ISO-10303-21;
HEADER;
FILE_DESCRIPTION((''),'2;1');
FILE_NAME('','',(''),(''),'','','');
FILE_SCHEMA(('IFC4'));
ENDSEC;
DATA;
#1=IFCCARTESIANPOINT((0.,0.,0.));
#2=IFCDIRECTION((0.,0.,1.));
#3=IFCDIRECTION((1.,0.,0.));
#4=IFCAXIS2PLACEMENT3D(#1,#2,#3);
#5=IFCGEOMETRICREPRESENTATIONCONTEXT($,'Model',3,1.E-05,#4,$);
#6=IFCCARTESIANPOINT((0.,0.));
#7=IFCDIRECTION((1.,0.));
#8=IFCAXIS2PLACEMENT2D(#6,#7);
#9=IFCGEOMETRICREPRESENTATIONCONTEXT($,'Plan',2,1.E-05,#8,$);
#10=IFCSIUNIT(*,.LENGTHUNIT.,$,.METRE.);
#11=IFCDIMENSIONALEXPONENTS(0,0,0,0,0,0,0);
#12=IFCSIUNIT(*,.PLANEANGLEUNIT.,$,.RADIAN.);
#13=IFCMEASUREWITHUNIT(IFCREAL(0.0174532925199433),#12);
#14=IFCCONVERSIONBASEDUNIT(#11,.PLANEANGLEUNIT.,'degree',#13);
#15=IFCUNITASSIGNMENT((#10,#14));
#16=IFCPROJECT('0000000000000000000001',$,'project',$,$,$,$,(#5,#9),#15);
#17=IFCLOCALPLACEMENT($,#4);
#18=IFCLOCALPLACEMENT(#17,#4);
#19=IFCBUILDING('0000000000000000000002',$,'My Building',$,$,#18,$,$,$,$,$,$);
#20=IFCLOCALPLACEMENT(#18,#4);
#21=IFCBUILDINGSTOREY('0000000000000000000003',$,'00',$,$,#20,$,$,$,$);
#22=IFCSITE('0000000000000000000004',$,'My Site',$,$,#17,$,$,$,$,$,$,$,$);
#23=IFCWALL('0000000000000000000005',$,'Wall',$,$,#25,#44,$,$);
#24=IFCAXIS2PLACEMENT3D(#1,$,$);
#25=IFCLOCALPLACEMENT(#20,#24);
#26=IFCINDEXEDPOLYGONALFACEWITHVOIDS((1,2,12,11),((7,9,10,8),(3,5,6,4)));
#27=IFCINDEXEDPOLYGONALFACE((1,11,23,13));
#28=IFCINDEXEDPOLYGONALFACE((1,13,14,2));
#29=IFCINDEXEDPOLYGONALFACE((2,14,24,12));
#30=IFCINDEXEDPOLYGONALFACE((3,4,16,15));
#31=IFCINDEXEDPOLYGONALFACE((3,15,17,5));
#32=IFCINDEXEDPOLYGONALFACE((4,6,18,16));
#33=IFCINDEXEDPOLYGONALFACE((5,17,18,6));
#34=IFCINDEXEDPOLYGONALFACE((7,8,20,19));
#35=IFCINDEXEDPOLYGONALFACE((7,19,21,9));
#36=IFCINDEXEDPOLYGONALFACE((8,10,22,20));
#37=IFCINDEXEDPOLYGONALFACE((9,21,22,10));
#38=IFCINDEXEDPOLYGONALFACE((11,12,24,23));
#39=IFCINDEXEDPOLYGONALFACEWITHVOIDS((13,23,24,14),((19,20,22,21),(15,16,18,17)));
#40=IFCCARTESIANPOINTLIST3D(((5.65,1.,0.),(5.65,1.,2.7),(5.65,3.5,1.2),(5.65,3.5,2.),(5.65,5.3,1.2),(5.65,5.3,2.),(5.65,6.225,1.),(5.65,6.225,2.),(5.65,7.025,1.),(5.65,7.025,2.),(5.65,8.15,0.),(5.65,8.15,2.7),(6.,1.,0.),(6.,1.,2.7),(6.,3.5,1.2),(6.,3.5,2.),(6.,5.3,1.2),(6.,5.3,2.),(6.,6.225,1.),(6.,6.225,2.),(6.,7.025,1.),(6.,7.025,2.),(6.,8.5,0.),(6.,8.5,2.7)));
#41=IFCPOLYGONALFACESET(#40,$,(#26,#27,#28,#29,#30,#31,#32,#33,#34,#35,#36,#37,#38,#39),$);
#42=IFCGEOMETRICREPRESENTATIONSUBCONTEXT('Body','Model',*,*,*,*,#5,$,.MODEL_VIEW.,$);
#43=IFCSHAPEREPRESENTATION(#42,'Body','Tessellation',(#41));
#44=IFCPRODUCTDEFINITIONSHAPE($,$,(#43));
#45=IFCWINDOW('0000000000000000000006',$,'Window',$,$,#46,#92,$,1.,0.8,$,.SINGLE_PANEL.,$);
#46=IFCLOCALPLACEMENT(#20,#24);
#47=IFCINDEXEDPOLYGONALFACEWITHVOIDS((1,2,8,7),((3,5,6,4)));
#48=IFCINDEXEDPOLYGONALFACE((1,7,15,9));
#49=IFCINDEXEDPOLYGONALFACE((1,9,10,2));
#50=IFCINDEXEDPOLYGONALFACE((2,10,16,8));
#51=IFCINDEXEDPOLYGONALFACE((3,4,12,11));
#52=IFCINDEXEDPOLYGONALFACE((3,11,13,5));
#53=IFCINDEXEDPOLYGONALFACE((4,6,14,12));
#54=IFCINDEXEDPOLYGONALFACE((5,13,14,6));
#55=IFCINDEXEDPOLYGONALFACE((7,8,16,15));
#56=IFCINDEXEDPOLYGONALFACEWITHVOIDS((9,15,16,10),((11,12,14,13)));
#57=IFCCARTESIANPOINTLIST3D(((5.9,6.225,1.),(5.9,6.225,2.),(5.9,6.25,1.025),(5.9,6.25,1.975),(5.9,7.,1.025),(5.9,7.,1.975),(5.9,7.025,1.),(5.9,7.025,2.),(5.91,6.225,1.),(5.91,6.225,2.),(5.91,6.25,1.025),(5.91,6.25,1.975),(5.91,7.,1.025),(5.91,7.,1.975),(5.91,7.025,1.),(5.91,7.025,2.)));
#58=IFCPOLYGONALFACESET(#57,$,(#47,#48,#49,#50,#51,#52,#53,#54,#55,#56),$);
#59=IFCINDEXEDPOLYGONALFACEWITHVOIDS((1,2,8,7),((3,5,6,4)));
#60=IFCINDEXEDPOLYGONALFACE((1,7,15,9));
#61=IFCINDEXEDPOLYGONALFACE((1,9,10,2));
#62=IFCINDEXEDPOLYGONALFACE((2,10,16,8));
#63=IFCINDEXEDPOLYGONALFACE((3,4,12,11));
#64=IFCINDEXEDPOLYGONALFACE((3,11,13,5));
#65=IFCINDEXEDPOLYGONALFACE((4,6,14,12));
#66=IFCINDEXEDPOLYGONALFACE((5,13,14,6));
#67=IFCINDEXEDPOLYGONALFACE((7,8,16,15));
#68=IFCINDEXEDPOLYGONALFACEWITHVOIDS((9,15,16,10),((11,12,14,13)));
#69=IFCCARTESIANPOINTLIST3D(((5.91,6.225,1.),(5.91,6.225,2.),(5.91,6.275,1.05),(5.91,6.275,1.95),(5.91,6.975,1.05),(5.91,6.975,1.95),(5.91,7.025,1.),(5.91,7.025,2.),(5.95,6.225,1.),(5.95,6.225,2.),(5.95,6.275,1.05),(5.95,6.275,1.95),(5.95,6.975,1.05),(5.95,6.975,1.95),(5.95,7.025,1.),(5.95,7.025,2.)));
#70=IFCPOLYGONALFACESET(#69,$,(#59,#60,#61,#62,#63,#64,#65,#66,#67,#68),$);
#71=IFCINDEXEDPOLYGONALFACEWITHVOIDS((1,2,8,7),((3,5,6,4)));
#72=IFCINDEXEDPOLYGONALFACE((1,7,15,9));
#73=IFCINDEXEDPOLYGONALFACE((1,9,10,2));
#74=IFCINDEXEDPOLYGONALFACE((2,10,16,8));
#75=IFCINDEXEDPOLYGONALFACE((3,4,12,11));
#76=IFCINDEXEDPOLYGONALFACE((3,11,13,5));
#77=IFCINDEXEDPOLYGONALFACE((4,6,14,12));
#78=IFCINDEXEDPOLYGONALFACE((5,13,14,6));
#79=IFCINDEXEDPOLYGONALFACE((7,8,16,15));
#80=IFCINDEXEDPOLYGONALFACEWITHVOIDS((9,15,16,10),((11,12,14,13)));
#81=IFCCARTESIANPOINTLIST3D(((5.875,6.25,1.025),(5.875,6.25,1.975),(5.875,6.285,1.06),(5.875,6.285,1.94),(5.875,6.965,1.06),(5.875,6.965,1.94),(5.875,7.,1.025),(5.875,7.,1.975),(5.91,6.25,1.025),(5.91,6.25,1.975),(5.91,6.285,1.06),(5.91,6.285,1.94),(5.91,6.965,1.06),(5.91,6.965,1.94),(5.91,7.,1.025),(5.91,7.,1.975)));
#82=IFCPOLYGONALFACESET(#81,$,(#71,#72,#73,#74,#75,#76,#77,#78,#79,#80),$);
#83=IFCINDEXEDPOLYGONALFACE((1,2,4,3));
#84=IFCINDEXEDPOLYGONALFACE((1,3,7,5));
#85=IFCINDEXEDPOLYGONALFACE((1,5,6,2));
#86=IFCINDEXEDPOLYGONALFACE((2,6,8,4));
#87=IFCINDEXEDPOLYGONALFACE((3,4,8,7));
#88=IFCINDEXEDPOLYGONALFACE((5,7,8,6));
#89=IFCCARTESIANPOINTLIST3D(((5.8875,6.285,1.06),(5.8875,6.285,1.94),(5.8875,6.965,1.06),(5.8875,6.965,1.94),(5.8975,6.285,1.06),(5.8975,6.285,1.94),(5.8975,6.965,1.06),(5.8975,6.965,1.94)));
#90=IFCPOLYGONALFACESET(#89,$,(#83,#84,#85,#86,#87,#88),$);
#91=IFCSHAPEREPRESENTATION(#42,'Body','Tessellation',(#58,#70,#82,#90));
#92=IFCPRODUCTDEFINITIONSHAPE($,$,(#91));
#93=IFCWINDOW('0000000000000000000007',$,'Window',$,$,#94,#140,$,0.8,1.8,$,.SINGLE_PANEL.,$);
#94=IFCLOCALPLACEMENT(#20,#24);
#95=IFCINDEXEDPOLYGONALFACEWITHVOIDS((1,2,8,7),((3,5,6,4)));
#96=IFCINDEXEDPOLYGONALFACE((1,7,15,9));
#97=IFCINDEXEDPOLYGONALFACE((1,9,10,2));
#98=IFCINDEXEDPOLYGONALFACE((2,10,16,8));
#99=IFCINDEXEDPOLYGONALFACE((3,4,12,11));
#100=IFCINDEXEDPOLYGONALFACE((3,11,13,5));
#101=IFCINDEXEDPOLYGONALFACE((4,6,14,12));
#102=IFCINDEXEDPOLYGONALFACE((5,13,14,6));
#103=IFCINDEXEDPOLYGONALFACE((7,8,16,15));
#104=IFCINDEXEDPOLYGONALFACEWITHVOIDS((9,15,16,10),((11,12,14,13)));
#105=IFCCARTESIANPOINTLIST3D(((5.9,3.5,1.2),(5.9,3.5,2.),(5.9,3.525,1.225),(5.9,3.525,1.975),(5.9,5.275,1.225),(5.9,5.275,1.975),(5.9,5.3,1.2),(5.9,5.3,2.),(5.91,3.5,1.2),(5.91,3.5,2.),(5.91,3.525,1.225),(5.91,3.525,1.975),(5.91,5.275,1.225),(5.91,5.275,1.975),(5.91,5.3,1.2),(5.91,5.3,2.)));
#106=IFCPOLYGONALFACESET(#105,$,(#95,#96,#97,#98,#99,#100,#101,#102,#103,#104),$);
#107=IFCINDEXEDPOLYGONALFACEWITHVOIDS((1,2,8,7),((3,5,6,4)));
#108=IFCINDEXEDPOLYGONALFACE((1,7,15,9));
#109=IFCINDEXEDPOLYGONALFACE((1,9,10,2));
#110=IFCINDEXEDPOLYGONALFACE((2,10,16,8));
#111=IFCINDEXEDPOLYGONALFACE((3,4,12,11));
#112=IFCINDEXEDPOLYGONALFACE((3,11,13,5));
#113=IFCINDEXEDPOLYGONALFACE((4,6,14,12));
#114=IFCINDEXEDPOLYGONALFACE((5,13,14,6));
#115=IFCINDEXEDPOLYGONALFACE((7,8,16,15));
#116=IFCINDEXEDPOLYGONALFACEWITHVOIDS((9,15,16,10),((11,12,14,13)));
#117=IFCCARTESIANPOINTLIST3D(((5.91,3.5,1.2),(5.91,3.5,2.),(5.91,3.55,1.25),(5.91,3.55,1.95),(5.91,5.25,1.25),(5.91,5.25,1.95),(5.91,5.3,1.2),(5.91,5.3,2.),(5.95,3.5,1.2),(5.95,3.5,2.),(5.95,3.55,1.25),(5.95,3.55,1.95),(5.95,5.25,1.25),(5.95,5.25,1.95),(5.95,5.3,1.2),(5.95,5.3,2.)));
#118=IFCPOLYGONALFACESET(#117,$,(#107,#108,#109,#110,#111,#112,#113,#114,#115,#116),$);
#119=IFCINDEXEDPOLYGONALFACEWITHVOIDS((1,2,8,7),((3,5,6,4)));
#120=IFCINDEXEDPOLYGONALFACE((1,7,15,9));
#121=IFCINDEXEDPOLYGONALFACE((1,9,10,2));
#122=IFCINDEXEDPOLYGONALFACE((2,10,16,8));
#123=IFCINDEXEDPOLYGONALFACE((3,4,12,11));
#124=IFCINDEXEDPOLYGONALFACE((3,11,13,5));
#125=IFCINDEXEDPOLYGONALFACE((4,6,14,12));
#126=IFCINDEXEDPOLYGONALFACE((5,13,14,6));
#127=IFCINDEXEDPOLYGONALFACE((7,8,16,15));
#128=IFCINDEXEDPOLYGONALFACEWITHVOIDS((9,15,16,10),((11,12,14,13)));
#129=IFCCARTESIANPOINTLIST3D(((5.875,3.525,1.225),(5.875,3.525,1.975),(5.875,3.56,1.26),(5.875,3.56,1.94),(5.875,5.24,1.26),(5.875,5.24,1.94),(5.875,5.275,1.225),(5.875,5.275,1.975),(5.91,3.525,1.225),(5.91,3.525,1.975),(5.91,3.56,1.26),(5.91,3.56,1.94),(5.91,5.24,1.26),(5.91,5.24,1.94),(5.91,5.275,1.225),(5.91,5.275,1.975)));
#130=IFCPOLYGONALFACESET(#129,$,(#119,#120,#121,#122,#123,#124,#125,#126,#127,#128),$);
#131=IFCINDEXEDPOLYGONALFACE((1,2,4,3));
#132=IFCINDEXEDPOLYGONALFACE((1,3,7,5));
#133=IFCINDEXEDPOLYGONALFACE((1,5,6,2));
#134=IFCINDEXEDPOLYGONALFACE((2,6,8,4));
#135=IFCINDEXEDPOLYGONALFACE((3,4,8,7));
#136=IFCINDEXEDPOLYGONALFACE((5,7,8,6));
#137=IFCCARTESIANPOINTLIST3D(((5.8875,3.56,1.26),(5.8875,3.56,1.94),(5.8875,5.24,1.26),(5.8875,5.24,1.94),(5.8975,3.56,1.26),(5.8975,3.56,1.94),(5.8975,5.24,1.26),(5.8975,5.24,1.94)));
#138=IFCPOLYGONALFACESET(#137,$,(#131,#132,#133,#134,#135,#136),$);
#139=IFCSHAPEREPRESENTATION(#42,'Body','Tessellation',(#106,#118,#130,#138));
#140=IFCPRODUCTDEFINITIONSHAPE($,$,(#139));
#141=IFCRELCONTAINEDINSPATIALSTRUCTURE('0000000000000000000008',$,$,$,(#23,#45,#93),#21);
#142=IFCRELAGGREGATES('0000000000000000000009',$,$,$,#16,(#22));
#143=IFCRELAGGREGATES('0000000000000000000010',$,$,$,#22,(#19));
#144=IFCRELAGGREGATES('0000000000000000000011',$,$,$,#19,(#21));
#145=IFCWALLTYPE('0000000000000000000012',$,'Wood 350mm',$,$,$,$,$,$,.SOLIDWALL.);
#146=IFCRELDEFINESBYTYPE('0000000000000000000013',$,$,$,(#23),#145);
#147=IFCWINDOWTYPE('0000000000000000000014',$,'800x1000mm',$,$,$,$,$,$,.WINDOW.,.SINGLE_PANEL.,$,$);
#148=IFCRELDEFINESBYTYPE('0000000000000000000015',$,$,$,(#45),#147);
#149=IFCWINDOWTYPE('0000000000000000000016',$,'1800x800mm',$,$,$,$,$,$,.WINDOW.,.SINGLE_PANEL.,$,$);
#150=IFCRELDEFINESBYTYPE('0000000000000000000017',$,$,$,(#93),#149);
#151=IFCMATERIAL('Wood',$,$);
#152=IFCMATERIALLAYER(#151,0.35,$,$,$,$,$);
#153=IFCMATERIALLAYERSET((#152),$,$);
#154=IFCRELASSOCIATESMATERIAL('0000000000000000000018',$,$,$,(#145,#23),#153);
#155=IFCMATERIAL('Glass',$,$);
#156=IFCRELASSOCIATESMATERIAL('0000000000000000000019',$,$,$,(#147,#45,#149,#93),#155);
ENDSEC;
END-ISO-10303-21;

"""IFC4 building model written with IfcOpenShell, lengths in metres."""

from ifc_helpers import new_model, entity, si_unit, converted_unit, frame, origin_with_axes, origin_2d_with_axis, place, context, subcontext, project, spatial, line, indexed_curve, outline, extrude, clip, halfspace, shape, source, transform, mapped, material, layer, layer_set, layer_usage, type_object, type_shapes, element, fill, save


model = new_model("IFC4")

# Units and contexts
model_context = context("Model", 3, precision=1e-05, world=origin_with_axes())
plan_context = context("Plan", 2, precision=1e-05, world=origin_2d_with_axis())
body_context_1 = subcontext(model_context, "Body", "Model", "MODEL_VIEW")
body_context_2 = subcontext(plan_context, "Body", "Plan", "PLAN_VIEW")
ifc_project = project(units=[si_unit("LENGTHUNIT", "METRE"), converted_unit("PLANEANGLEUNIT", "degree", entity("IfcReal", 0.0174532925199433), si_unit("PLANEANGLEUNIT", "RADIAN"), dimensions=[0, 0, 0, 0, 0, 0, 0])], contexts=[model_context, plan_context])

# Site, building, storey
site_placement = place(None, origin_with_axes())
site = spatial("IfcSite", under=ifc_project, at=site_placement, Name="My Site")
building_placement = place(site_placement, origin_with_axes())
building = spatial("IfcBuilding", under=site, at=building_placement, Name="My Building")
storey_placement = place(building_placement, origin_with_axes())
storey = spatial("IfcBuildingStorey", under=building, at=storey_placement, Name="00")

# Shared definitions
ifc_material_1 = material(Name="Wood")

# Wall, openings, windows
ifc_layer_1 = layer(ifc_material_1, 0.35)
ifc_layer_set_1 = layer_set([ifc_layer_1])
ifc_layer_usage_1 = layer_usage(ifc_layer_set_1, "AXIS2", "POSITIVE", 0.0)
wall_type_1 = type_object("IfcWallType", Name="Wood 350mm", PredefinedType="SOLIDWALL", material=ifc_layer_set_1)
wall_1_placement = place(storey_placement, frame((6.0, 1.0, 0.0), z_axis=(0.0, 0.0, 1.0), x_axis=(0.0, 1.0, 0.0)))
wall_1 = element("IfcWall", 1, at=wall_1_placement, inside=storey, type_object=wall_type_1, material=ifc_layer_usage_1, Name="Wall", context=body_context_1, shape_type="Clipping", body=[
    clip(extrude(outline(indexed_curve([(0.0, 0.0), (0.0, 0.35), (7.5, 0.35), (7.5, 0.0), (0.0, 0.0)], self_intersect=False)), origin_with_axes(), (0.0, 0.0, 1.0), 2.7), halfspace(frame((7.5, 0.0, 0.0), z_axis=(0.707107, 0.707107, 0.0), x_axis=(0.707107, -0.707107, 0.0)), False)),
])
shared_shape_1 = source(origin_with_axes(), body_context_1, "Body", "SweptSolid", [
    extrude(outline(indexed_curve([(0.0, 0.0), (0.8, 0.0), (0.8, 1.0), (0.0, 1.0)], segments=[line(1, 2, 3, 4, 1)])), frame((0.0, -0.6, 0.0), z_axis=(0.0, -1.0, 0.0), x_axis=(1.0, 0.0, 0.0)), (0.0, 0.0, -1.0), 1.2),
])
opening_1_placement = place(wall_1_placement, frame((5.225, 0.0, 1.0), z_axis=(0.0, 0.0, 1.0), x_axis=(1.0, 0.0, 0.0)))
opening_1 = element("IfcOpeningElement", 2, at=opening_1_placement, cuts=wall_1, PredefinedType="OPENING", context=body_context_1, shape_type="MappedRepresentation", body=[
    mapped(shared_shape_1, transform((0.0, 0.0, 0.0), x_axis=(1.0, 0.0, 0.0), y_axis=(0.0, 1.0, 0.0), z_axis=(0.0, 0.0, 1.0), scale=1.0)),
])
shared_shape_2 = source(origin_with_axes(), body_context_1, "Body", "SweptSolid", [
    extrude(outline(indexed_curve([(0.0, 0.0), (1.8, 0.0), (1.8, 0.8), (0.0, 0.8)], segments=[line(1, 2, 3, 4, 1)])), frame((0.0, -0.6, 0.0), z_axis=(0.0, -1.0, 0.0), x_axis=(1.0, 0.0, 0.0)), (0.0, 0.0, -1.0), 1.2),
])
opening_2_placement = place(wall_1_placement, frame((2.5, 0.0, 1.2), z_axis=(0.0, 0.0, 1.0), x_axis=(1.0, 0.0, 0.0)))
opening_2 = element("IfcOpeningElement", 3, at=opening_2_placement, cuts=wall_1, PredefinedType="OPENING", context=body_context_1, shape_type="MappedRepresentation", body=[
    mapped(shared_shape_2, transform((0.0, 0.0, 0.0), x_axis=(1.0, 0.0, 0.0), y_axis=(0.0, 1.0, 0.0), z_axis=(0.0, 0.0, 1.0), scale=1.0)),
])
ifc_material_2 = material(Name="Glass")
window_type_1 = type_object("IfcWindowType", Name="800x1000mm", PartitioningType="SINGLE_PANEL", PredefinedType="WINDOW", material=ifc_material_2)
shared_shape_3 = source(origin_with_axes(), body_context_1, "Body", "SweptSolid", [
    extrude(outline(indexed_curve([(0.0, 0.0), (0.8, 0.0), (0.8, 1.0), (0.0, 1.0)], segments=[line(1, 2, 3, 4, 1)]), holes=[indexed_curve([(0.025, 0.025), (0.775, 0.025), (0.775, 0.975), (0.025, 0.975)], segments=[line(1, 2, 3, 4, 1)])]), frame((0.0, 0.09, 0.0), z_axis=(0.0, -1.0, 0.0), x_axis=(1.0, 0.0, 0.0)), (0.0, 0.0, -1.0), 0.01),
    extrude(outline(indexed_curve([(0.0, 0.0), (0.8, 0.0), (0.8, 1.0), (0.0, 1.0)], segments=[line(1, 2, 3, 4, 1)]), holes=[indexed_curve([(0.05, 0.05), (0.75, 0.05), (0.75, 0.95), (0.05, 0.95)], segments=[line(1, 2, 3, 4, 1)])]), frame((0.0, 0.05, 0.0), z_axis=(0.0, -1.0, 0.0), x_axis=(1.0, 0.0, 0.0)), (0.0, 0.0, -1.0), 0.04),
    extrude(outline(indexed_curve([(0.0, 0.0), (0.75, 0.0), (0.75, 0.95), (0.0, 0.95)], segments=[line(1, 2, 3, 4, 1)]), holes=[indexed_curve([(0.035, 0.035), (0.715, 0.035), (0.715, 0.915), (0.035, 0.915)], segments=[line(1, 2, 3, 4, 1)])]), frame((0.025, 0.09, 0.025), z_axis=(0.0, -1.0, 0.0), x_axis=(1.0, 0.0, 0.0)), (0.0, 0.0, -1.0), 0.035),
    extrude(outline(indexed_curve([(0.035, 0.035), (0.715, 0.035), (0.715, 0.915), (0.035, 0.915)], segments=[line(1, 2, 3, 4, 1)])), frame((0.025, 0.1025, 0.025), z_axis=(0.0, -1.0, 0.0), x_axis=(1.0, 0.0, 0.0)), (0.0, 0.0, -1.0), 0.01),
])
shared_shape_4 = source(origin_with_axes(), body_context_2, "Body", "Curve2D", [
    entity("IfcIndexedPolyCurve", entity("IfcCartesianPointList2D", [[0.05, 0.05], [0.75, 0.05]])),
    entity("IfcIndexedPolyCurve", entity("IfcCartesianPointList2D", [[0.0, 0.1], [0.025, 0.1], [0.025, 0.09], [0.05, 0.09], [0.05, 0.05], [0.0, 0.05]]), [entity("IfcLineIndex", [1, 2, 3, 4, 5, 6, 1])]),
    entity("IfcIndexedPolyCurve", entity("IfcCartesianPointList2D", [[0.8, 0.1], [0.775, 0.1], [0.775, 0.09], [0.75, 0.09], [0.75, 0.05], [0.8, 0.05]]), [entity("IfcLineIndex", [1, 2, 3, 4, 5, 6, 1])]),
    entity("IfcIndexedPolyCurve", entity("IfcCartesianPointList2D", [[0.025, 0.09], [0.06, 0.09], [0.06, 0.125], [0.025, 0.125]]), [entity("IfcLineIndex", [1, 2, 3, 4, 1])]),
    entity("IfcIndexedPolyCurve", entity("IfcCartesianPointList2D", [[0.775, 0.09], [0.74, 0.09], [0.74, 0.125], [0.775, 0.125]]), [entity("IfcLineIndex", [1, 2, 3, 4, 1])]),
    entity("IfcIndexedPolyCurve", entity("IfcCartesianPointList2D", [[0.06, 0.09], [0.74, 0.09]])),
    entity("IfcIndexedPolyCurve", entity("IfcCartesianPointList2D", [[0.06, 0.125], [0.74, 0.125]])),
    entity("IfcIndexedPolyCurve", entity("IfcCartesianPointList2D", [[0.06, 0.1075], [0.74, 0.1075]])),
])
type_shapes(window_type_1, [shared_shape_3, shared_shape_4])
window_1_placement = place(opening_1_placement, origin_with_axes())
window_1 = element("IfcWindow", 4, at=window_1_placement, inside=storey, type_object=window_type_1, material=ifc_material_2, Name="Window", OverallHeight=1.0, OverallWidth=0.8, PartitioningType="SINGLE_PANEL", shapes=[
    shape(body_context_1, "Body", "MappedRepresentation", [mapped(shared_shape_3, transform((0.0, 0.0, 0.0), x_axis=(1.0, 0.0, 0.0), y_axis=(0.0, 1.0, 0.0), z_axis=(0.0, 0.0, 1.0), scale=1.0))]),
    shape(body_context_2, "Body", "MappedRepresentation", [mapped(shared_shape_4, transform((0.0, 0.0, 0.0), x_axis=(1.0, 0.0, 0.0), y_axis=(0.0, 1.0, 0.0), z_axis=(0.0, 0.0, 1.0), scale=1.0))]),
])
fill(opening_1, window_1)
window_type_2 = type_object("IfcWindowType", Name="1800x800mm", PartitioningType="SINGLE_PANEL", PredefinedType="WINDOW", material=ifc_material_2)
shared_shape_5 = source(origin_with_axes(), body_context_1, "Body", "SweptSolid", [
    extrude(outline(indexed_curve([(0.0, 0.0), (1.8, 0.0), (1.8, 0.8), (0.0, 0.8)], segments=[line(1, 2, 3, 4, 1)]), holes=[indexed_curve([(0.025, 0.025), (1.775, 0.025), (1.775, 0.775), (0.025, 0.775)], segments=[line(1, 2, 3, 4, 1)])]), frame((0.0, 0.09, 0.0), z_axis=(0.0, -1.0, 0.0), x_axis=(1.0, 0.0, 0.0)), (0.0, 0.0, -1.0), 0.01),
    extrude(outline(indexed_curve([(0.0, 0.0), (1.8, 0.0), (1.8, 0.8), (0.0, 0.8)], segments=[line(1, 2, 3, 4, 1)]), holes=[indexed_curve([(0.05, 0.05), (1.75, 0.05), (1.75, 0.75), (0.05, 0.75)], segments=[line(1, 2, 3, 4, 1)])]), frame((0.0, 0.05, 0.0), z_axis=(0.0, -1.0, 0.0), x_axis=(1.0, 0.0, 0.0)), (0.0, 0.0, -1.0), 0.04),
    extrude(outline(indexed_curve([(0.0, 0.0), (1.75, 0.0), (1.75, 0.75), (0.0, 0.75)], segments=[line(1, 2, 3, 4, 1)]), holes=[indexed_curve([(0.035, 0.035), (1.715, 0.035), (1.715, 0.715), (0.035, 0.715)], segments=[line(1, 2, 3, 4, 1)])]), frame((0.025, 0.09, 0.025), z_axis=(0.0, -1.0, 0.0), x_axis=(1.0, 0.0, 0.0)), (0.0, 0.0, -1.0), 0.035),
    extrude(outline(indexed_curve([(0.035, 0.035), (1.715, 0.035), (1.715, 0.715), (0.035, 0.715)], segments=[line(1, 2, 3, 4, 1)])), frame((0.025, 0.1025, 0.025), z_axis=(0.0, -1.0, 0.0), x_axis=(1.0, 0.0, 0.0)), (0.0, 0.0, -1.0), 0.01),
])
shared_shape_6 = source(origin_with_axes(), body_context_2, "Body", "Curve2D", [
    entity("IfcIndexedPolyCurve", entity("IfcCartesianPointList2D", [[0.05, 0.05], [1.75, 0.05]])),
    entity("IfcIndexedPolyCurve", entity("IfcCartesianPointList2D", [[0.0, 0.1], [0.025, 0.1], [0.025, 0.09], [0.05, 0.09], [0.05, 0.05], [0.0, 0.05]]), [entity("IfcLineIndex", [1, 2, 3, 4, 5, 6, 1])]),
    entity("IfcIndexedPolyCurve", entity("IfcCartesianPointList2D", [[1.8, 0.1], [1.775, 0.1], [1.775, 0.09], [1.75, 0.09], [1.75, 0.05], [1.8, 0.05]]), [entity("IfcLineIndex", [1, 2, 3, 4, 5, 6, 1])]),
    entity("IfcIndexedPolyCurve", entity("IfcCartesianPointList2D", [[0.025, 0.09], [0.06, 0.09], [0.06, 0.125], [0.025, 0.125]]), [entity("IfcLineIndex", [1, 2, 3, 4, 1])]),
    entity("IfcIndexedPolyCurve", entity("IfcCartesianPointList2D", [[1.775, 0.09], [1.74, 0.09], [1.74, 0.125], [1.775, 0.125]]), [entity("IfcLineIndex", [1, 2, 3, 4, 1])]),
    entity("IfcIndexedPolyCurve", entity("IfcCartesianPointList2D", [[0.06, 0.09], [1.74, 0.09]])),
    entity("IfcIndexedPolyCurve", entity("IfcCartesianPointList2D", [[0.06, 0.125], [1.74, 0.125]])),
    entity("IfcIndexedPolyCurve", entity("IfcCartesianPointList2D", [[0.06, 0.1075], [1.74, 0.1075]])),
])
type_shapes(window_type_2, [shared_shape_5, shared_shape_6])
window_2_placement = place(opening_2_placement, frame((0.0, 0.0, 0.0), z_axis=(0.0, 0.0, 1.0), x_axis=(1.0, 0.0, 0.0)))
window_2 = element("IfcWindow", 5, at=window_2_placement, inside=storey, type_object=window_type_2, material=ifc_material_2, Name="Window", OverallHeight=0.8, OverallWidth=1.8, PartitioningType="SINGLE_PANEL", shapes=[
    shape(body_context_1, "Body", "MappedRepresentation", [mapped(shared_shape_5, transform((0.0, 0.0, 0.0), x_axis=(1.0, 0.0, 0.0), y_axis=(0.0, 1.0, 0.0), z_axis=(0.0, 0.0, 1.0), scale=1.0))]),
    shape(body_context_2, "Body", "MappedRepresentation", [mapped(shared_shape_6, transform((0.0, 0.0, 0.0), x_axis=(1.0, 0.0, 0.0), y_axis=(0.0, 1.0, 0.0), z_axis=(0.0, 0.0, 1.0), scale=1.0))]),
])
fill(opening_2, window_2)

save(model, "model.ifc")
